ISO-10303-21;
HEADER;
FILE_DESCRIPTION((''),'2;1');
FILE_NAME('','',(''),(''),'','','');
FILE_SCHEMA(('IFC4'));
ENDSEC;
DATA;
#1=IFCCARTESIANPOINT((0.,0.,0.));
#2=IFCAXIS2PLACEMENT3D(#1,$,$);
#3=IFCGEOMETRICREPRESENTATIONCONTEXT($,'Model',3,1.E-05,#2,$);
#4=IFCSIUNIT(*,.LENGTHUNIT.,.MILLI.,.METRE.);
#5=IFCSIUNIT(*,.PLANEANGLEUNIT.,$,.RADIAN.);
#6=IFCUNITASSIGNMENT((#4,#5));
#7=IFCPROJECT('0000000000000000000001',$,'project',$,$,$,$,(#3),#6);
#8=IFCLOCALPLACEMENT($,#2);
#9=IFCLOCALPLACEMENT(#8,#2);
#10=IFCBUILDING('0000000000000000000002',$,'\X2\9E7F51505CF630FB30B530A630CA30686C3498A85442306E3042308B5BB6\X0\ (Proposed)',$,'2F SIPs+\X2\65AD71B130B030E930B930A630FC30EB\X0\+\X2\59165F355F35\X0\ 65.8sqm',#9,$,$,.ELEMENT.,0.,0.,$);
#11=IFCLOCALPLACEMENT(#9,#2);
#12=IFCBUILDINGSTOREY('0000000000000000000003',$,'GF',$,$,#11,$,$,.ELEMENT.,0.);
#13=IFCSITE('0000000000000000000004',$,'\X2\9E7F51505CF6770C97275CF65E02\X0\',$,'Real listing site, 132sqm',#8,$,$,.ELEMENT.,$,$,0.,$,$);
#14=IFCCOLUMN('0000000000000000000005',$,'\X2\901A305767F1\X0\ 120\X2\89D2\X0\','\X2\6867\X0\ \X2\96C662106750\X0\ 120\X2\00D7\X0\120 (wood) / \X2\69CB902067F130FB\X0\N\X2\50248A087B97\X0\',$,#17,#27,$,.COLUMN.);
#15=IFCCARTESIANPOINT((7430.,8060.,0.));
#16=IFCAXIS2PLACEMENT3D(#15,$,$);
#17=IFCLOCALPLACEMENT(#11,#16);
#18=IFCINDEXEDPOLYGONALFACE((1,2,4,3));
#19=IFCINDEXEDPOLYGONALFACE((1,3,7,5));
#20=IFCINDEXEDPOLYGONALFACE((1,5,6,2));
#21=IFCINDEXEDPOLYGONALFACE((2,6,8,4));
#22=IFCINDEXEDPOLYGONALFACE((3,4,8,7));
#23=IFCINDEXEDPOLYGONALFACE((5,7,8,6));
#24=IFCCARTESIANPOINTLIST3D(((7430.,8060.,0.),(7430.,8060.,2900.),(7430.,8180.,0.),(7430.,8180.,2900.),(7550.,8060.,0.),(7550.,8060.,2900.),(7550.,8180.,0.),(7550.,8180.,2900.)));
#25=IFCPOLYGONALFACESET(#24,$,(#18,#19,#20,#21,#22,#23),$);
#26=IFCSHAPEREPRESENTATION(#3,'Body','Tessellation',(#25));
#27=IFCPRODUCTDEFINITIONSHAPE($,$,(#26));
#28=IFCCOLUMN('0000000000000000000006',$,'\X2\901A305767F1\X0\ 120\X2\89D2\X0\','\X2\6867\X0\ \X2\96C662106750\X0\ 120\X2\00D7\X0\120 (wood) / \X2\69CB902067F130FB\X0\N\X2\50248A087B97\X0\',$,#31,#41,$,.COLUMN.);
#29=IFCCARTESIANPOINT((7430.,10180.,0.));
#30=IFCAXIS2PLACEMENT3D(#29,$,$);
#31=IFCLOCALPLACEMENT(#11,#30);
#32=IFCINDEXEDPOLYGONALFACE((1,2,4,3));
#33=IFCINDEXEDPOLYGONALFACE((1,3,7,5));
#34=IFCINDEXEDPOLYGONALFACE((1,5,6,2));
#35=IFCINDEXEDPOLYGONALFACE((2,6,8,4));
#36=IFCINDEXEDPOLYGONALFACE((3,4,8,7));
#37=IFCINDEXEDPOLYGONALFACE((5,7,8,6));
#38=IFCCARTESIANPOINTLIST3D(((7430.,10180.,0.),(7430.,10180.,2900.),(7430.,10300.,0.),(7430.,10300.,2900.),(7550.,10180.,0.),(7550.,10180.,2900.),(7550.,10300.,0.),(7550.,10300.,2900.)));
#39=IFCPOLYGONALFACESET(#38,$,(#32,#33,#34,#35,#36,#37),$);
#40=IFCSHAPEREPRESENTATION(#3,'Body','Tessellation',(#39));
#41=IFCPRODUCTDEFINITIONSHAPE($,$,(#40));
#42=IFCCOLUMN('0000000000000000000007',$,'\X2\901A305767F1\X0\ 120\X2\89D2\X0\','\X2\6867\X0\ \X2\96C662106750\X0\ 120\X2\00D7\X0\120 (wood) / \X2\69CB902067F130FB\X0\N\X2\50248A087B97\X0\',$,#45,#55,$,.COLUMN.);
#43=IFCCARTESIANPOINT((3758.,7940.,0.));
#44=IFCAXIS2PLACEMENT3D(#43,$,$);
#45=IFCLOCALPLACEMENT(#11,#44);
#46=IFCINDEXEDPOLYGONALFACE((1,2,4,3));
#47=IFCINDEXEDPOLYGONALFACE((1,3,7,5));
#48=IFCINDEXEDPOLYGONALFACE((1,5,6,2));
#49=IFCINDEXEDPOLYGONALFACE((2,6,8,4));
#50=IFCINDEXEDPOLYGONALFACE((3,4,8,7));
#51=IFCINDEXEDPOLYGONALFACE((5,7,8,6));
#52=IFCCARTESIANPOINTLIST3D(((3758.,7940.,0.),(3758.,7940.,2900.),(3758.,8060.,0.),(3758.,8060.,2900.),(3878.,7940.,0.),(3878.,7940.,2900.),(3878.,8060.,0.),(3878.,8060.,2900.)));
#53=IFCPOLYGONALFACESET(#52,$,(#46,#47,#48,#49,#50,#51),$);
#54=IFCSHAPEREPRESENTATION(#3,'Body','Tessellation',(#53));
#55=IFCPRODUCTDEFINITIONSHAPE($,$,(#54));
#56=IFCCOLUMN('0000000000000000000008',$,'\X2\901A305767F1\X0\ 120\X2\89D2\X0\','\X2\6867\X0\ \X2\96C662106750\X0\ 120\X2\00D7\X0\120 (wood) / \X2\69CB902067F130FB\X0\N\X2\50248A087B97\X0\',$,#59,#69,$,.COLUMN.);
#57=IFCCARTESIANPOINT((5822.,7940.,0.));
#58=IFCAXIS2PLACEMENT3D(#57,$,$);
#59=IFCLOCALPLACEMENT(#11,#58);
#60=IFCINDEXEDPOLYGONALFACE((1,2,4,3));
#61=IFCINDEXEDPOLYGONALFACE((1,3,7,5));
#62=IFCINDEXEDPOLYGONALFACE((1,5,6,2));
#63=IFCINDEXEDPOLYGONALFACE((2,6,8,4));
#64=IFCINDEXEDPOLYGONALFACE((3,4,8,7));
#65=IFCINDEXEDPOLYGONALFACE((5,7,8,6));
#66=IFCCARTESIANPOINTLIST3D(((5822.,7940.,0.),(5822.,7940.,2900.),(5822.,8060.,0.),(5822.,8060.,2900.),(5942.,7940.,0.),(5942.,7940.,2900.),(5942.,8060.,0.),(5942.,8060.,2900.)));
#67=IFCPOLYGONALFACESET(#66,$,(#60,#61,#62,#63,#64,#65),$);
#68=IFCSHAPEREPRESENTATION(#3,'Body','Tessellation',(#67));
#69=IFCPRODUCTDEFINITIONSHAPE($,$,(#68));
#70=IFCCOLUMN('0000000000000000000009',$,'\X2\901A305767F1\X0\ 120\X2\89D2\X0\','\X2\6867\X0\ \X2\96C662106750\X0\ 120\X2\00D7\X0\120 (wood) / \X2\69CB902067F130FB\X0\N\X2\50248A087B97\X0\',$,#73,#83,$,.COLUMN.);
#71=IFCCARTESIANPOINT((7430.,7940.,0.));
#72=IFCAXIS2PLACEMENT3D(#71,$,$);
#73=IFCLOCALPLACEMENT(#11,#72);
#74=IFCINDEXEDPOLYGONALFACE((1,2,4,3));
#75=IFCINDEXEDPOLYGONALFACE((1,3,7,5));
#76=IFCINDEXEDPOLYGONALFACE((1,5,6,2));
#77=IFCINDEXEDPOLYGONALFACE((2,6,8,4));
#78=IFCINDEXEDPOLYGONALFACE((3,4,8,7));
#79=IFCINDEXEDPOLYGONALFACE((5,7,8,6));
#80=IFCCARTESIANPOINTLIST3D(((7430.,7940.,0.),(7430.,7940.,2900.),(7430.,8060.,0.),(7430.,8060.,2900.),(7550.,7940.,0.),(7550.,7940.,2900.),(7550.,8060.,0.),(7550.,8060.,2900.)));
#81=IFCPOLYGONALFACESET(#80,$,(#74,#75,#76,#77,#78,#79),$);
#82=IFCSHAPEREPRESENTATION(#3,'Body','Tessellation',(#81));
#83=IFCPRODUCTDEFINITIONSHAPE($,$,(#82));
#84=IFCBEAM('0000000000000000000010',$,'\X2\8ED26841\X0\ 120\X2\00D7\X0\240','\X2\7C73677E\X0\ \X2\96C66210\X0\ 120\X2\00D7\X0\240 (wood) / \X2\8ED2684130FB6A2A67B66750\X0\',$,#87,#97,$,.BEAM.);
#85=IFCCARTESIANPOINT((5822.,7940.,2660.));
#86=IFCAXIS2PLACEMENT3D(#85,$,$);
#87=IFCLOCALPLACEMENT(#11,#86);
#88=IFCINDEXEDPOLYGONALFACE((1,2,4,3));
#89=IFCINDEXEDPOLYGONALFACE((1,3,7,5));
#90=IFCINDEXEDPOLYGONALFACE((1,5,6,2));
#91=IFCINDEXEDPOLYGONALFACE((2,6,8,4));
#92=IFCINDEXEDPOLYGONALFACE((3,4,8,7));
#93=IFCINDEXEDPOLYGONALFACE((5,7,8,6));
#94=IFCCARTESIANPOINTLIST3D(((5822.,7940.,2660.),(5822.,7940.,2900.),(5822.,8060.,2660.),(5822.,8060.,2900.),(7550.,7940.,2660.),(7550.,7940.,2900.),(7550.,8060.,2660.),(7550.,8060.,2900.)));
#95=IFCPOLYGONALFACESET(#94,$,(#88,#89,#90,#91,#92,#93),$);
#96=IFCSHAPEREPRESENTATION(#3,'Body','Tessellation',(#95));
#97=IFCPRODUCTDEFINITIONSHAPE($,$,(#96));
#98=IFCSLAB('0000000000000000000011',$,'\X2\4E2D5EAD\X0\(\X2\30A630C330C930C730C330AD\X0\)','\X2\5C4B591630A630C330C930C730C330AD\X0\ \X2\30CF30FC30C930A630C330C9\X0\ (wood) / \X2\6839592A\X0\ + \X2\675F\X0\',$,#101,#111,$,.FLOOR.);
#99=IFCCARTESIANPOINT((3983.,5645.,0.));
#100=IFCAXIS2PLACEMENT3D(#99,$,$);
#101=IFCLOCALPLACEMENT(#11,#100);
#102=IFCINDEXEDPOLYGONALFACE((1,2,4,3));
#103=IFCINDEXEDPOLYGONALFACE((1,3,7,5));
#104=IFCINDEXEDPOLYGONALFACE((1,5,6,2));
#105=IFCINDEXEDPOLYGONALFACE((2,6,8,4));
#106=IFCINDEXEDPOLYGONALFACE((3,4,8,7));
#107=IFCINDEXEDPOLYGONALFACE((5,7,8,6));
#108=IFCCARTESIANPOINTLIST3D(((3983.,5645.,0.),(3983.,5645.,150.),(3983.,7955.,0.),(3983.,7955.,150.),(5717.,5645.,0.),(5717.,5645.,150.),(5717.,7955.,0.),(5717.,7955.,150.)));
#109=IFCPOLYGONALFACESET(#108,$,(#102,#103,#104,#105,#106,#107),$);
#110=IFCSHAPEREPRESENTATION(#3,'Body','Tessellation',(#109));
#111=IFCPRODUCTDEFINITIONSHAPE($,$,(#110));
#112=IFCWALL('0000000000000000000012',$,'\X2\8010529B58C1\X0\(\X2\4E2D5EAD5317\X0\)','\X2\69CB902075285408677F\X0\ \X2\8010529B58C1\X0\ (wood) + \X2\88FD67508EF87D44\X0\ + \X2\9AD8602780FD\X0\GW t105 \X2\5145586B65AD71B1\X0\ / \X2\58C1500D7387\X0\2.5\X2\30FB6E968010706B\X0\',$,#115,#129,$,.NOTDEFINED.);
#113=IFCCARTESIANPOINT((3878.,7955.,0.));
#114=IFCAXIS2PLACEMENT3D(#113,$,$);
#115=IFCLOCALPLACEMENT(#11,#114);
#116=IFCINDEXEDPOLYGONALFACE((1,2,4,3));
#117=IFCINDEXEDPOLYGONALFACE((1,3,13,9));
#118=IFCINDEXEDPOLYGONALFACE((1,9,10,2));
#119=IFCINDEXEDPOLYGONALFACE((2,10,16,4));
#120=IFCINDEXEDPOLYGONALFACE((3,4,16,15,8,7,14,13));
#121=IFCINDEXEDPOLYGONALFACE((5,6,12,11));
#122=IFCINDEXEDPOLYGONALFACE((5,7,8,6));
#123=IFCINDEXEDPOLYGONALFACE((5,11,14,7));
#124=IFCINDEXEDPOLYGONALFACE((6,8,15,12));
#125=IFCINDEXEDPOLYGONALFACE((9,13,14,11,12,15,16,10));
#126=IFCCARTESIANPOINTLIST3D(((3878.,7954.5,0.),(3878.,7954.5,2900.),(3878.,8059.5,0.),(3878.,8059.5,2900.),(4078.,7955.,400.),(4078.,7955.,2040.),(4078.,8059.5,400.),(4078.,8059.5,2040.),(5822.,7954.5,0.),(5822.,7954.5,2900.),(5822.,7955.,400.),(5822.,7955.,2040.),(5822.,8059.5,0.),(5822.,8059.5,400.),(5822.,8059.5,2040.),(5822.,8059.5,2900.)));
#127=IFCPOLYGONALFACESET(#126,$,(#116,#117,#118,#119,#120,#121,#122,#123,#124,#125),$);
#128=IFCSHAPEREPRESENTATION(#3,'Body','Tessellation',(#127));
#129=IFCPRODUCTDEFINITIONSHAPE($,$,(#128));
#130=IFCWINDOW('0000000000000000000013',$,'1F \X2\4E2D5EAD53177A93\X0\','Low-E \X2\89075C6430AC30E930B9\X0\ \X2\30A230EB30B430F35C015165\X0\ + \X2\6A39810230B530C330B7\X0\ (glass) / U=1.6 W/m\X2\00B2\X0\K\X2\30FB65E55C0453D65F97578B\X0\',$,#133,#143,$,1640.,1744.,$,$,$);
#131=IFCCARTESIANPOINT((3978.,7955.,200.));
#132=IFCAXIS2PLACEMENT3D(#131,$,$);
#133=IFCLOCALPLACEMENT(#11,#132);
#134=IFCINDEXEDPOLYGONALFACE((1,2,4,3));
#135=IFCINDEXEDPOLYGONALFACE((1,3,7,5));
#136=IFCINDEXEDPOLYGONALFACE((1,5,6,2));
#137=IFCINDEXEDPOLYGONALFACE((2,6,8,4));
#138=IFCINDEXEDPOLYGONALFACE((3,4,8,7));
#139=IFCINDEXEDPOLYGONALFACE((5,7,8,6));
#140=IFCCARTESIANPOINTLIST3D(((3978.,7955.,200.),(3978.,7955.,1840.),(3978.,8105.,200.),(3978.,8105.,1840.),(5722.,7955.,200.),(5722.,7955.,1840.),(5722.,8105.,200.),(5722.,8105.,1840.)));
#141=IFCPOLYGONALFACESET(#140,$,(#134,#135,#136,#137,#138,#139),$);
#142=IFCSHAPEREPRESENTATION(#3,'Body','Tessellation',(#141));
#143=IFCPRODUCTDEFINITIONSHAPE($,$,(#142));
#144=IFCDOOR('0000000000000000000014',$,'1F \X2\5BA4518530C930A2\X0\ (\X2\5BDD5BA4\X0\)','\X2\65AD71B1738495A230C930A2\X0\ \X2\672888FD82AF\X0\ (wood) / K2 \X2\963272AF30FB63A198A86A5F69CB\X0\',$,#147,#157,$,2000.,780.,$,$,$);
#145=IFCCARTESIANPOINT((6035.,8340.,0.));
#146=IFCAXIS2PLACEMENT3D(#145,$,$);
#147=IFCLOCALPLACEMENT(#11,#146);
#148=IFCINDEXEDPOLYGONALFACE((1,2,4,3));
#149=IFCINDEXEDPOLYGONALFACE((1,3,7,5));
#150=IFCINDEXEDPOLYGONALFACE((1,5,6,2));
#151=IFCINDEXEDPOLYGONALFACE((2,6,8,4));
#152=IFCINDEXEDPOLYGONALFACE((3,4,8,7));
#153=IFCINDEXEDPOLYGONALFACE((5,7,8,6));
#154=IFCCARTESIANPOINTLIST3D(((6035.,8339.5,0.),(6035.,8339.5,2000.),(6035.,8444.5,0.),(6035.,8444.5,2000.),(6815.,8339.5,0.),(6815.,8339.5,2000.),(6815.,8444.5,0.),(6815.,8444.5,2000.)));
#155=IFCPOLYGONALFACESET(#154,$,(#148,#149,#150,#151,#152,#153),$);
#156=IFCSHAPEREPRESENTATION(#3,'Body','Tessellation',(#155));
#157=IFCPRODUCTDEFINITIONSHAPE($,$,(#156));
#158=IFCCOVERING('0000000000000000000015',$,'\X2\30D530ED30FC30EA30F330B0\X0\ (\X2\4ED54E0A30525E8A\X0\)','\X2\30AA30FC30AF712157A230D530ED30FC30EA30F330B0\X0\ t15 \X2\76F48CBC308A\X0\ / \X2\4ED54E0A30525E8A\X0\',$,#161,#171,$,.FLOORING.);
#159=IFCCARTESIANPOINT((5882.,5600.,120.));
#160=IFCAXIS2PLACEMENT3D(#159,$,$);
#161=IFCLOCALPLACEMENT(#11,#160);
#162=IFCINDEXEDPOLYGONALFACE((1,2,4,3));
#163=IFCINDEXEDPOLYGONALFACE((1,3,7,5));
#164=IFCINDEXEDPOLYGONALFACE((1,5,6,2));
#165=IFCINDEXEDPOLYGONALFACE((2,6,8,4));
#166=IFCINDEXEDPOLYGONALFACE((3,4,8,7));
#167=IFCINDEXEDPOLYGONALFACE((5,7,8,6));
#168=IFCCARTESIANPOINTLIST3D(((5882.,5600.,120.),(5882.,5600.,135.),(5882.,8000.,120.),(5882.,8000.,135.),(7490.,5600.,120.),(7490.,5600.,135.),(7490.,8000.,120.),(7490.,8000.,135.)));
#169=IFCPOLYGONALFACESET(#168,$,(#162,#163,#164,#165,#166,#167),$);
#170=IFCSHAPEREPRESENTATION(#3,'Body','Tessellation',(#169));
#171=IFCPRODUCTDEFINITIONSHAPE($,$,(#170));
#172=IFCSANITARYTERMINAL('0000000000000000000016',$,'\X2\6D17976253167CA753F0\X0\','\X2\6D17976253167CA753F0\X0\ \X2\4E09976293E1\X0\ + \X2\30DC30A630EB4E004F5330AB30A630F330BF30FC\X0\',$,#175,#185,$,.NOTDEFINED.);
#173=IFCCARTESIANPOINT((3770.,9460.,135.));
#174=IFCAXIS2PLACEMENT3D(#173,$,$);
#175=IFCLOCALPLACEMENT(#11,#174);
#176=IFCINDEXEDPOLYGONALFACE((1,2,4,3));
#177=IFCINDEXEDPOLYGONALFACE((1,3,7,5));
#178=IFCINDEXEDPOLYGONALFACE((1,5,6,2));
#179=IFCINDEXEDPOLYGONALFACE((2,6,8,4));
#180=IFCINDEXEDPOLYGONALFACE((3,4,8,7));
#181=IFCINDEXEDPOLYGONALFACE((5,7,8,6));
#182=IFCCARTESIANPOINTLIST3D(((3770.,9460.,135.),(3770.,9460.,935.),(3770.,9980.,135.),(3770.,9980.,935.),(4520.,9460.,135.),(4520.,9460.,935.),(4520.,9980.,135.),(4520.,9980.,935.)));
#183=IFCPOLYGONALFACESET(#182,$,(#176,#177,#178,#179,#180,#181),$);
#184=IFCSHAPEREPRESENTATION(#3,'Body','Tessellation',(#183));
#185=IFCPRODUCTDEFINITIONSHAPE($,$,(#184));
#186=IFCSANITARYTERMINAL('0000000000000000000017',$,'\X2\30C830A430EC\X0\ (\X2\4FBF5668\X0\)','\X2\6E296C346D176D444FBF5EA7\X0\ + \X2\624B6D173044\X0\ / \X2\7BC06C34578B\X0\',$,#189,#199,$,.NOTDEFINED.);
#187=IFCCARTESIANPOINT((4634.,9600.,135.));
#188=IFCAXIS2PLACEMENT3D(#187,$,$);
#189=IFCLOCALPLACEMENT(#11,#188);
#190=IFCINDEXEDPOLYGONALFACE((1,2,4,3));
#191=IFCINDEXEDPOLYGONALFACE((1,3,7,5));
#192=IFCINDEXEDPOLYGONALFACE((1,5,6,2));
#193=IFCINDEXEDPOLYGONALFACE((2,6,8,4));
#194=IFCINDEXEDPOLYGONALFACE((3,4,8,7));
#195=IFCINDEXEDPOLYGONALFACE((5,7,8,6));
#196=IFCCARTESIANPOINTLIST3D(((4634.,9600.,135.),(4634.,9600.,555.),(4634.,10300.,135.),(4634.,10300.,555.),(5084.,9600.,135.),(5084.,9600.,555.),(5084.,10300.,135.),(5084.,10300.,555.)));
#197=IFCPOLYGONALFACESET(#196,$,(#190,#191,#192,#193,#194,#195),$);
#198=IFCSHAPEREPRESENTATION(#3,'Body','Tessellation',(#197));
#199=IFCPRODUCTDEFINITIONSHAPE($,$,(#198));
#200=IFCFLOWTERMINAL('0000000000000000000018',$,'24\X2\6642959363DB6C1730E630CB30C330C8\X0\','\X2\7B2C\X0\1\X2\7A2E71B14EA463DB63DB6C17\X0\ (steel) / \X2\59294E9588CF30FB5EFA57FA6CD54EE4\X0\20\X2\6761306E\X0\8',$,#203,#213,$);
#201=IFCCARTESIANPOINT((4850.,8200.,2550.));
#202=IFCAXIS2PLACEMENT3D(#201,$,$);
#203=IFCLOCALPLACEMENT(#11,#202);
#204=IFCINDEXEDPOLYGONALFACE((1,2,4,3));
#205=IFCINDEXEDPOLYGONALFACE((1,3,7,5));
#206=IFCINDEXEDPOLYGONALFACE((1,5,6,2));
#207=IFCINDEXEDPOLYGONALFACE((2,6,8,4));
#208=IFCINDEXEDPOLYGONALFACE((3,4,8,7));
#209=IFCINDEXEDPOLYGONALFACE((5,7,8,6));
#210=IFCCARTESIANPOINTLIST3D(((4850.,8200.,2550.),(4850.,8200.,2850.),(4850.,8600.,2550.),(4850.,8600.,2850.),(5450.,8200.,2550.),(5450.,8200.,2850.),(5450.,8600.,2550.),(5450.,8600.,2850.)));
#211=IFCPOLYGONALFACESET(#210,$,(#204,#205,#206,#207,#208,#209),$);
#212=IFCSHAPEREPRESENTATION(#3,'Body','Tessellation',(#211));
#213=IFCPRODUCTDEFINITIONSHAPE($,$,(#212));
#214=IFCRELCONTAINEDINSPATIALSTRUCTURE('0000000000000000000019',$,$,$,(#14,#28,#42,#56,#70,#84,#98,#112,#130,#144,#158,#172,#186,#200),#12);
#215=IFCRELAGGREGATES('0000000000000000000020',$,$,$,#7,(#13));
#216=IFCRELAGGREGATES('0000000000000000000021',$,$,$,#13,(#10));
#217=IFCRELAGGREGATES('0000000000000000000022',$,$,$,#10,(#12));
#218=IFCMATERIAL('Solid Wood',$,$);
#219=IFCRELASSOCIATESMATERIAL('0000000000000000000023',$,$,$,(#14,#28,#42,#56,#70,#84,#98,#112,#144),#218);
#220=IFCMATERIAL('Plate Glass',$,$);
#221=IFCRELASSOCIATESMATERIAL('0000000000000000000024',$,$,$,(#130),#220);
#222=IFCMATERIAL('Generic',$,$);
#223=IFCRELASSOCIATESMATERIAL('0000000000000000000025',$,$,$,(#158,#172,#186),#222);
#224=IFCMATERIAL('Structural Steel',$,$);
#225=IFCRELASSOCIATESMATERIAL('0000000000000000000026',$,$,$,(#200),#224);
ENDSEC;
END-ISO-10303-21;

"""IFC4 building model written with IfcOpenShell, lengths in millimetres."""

from ifc_helpers import new_model, si_unit, frame, frame_2d, origin, place, context, project, spatial, rectangle, extrude, material, element, fill, save


model = new_model("IFC4")

# Units and contexts
model_context = context("Model", 3, precision=1e-05, world=origin())
ifc_project = project(units=[si_unit("LENGTHUNIT", "METRE", prefix="MILLI"), si_unit("PLANEANGLEUNIT", "RADIAN")], contexts=[model_context])

# Site, building, storey
site_placement = place(None, origin())
site = spatial("IfcSite", under=ifc_project, at=site_placement, Name="鹿児島県霧島市", ObjectType="Real listing site, 132sqm", CompositionType="ELEMENT", RefElevation=0.0)
building_placement = place(site_placement, origin())
building = spatial("IfcBuilding", under=site, at=building_placement, Name="鹿児島・サウナと水風呂のある家 (Proposed)", ObjectType="2F SIPs+断熱グラスウール+外張張 65.8sqm", CompositionType="ELEMENT", ElevationOfRefHeight=0.0, ElevationOfTerrain=0.0)
storey_placement = place(building_placement, origin())
storey = spatial("IfcBuildingStorey", under=building, at=storey_placement, Name="GF", CompositionType="ELEMENT", Elevation=0.0)

# Columns
ifc_material_1 = material(Name="Solid Wood")
column_1_placement = place(storey_placement, frame((7430.0, 8060.0, 0.0)))
element("IfcColumn", 1, at=column_1_placement, inside=storey, material=ifc_material_1, Name="通し柱 120角", Description="桧 集成材 120×120 (wood) / 構造柱・N値計算", PredefinedType="COLUMN", context=model_context, shape_type="SweptSolid", body=[
    extrude(rectangle(XDim=120.0, YDim=120.0, at=frame_2d((60.0, 60.0))), frame((7430.0, 8060.0, 0.0)), (0.0, 0.0, 1.0), 2900.0),
])
column_2_placement = place(storey_placement, frame((7430.0, 10180.0, 0.0)))
element("IfcColumn", 2, at=column_2_placement, inside=storey, material=ifc_material_1, Name="通し柱 120角", Description="桧 集成材 120×120 (wood) / 構造柱・N値計算", PredefinedType="COLUMN", context=model_context, shape_type="SweptSolid", body=[
    extrude(rectangle(XDim=120.0, YDim=120.0, at=frame_2d((60.0, 60.0))), frame((7430.0, 10180.0, 0.0)), (0.0, 0.0, 1.0), 2900.0),
])
column_3_placement = place(storey_placement, frame((3758.0, 7940.0, 0.0)))
element("IfcColumn", 3, at=column_3_placement, inside=storey, material=ifc_material_1, Name="通し柱 120角", Description="桧 集成材 120×120 (wood) / 構造柱・N値計算", PredefinedType="COLUMN", context=model_context, shape_type="SweptSolid", body=[
    extrude(rectangle(XDim=120.0, YDim=120.0, at=frame_2d((60.0, 60.0))), frame((3758.0, 7940.0, 0.0)), (0.0, 0.0, 1.0), 2900.0),
])
column_4_placement = place(storey_placement, frame((5822.0, 7940.0, 0.0)))
element("IfcColumn", 4, at=column_4_placement, inside=storey, material=ifc_material_1, Name="通し柱 120角", Description="桧 集成材 120×120 (wood) / 構造柱・N値計算", PredefinedType="COLUMN", context=model_context, shape_type="SweptSolid", body=[
    extrude(rectangle(XDim=120.0, YDim=120.0, at=frame_2d((60.0, 60.0))), frame((5822.0, 7940.0, 0.0)), (0.0, 0.0, 1.0), 2900.0),
])
column_5_placement = place(storey_placement, frame((7430.0, 7940.0, 0.0)))
element("IfcColumn", 5, at=column_5_placement, inside=storey, material=ifc_material_1, Name="通し柱 120角", Description="桧 集成材 120×120 (wood) / 構造柱・N値計算", PredefinedType="COLUMN", context=model_context, shape_type="SweptSolid", body=[
    extrude(rectangle(XDim=120.0, YDim=120.0, at=frame_2d((60.0, 60.0))), frame((7430.0, 7940.0, 0.0)), (0.0, 0.0, 1.0), 2900.0),
])

# Beam
beam_1_placement = place(storey_placement, frame((5822.0, 7940.0, 2660.0)))
element("IfcBeam", 6, at=beam_1_placement, inside=storey, material=ifc_material_1, Name="軒桁 120×240", Description="米松 集成 120×240 (wood) / 軒桁・横架材", PredefinedType="BEAM", context=model_context, shape_type="SweptSolid", body=[
    extrude(rectangle(XDim=1728.0, YDim=120.0, at=frame_2d((864.0, 60.0))), frame((5822.0, 7940.0, 2660.0)), (0.0, 0.0, 1.0), 240.0),
])

# Slab
slab_placement = place(storey_placement, frame((3983.0, 5645.0, 0.0)))
element("IfcSlab", 7, at=slab_placement, inside=storey, material=ifc_material_1, Name="中庭(ウッドデッキ)", Description="屋外ウッドデッキ ハードウッド (wood) / 根太 + 束", PredefinedType="FLOOR", context=model_context, shape_type="SweptSolid", body=[
    extrude(rectangle(XDim=1734.0, YDim=2310.0, at=frame_2d((867.0, 1155.0))), frame((3983.0, 5645.0, 0.0)), (0.0, 0.0, 1.0), 150.0),
])

# Wall, opening, window
wall_1_placement = place(storey_placement, frame((3878.0, 7955.0, 0.0)))
wall_1 = element("IfcWall", 8, at=wall_1_placement, inside=storey, material=ifc_material_1, Name="耐力壁(中庭北)", Description="構造用合板 耐力壁 (wood) + 製材軸組 + 高性能GW t105 充填断熱 / 壁倍率2.5・準耐火", PredefinedType="NOTDEFINED", context=model_context, shape_type="SweptSolid", body=[
    extrude(rectangle(XDim=1944.0, YDim=105.0, at=frame_2d((972.0, 52.0))), frame((3878.0, 7955.0, 0.0)), (0.0, 0.0, 1.0), 2900.0),
])
opening_placement = place(storey_placement, frame((3978.0, 7955.0, 200.0)))
opening = element("IfcOpeningElement", 9, at=opening_placement, cuts=wall_1, PredefinedType="NOTDEFINED", context=model_context, shape_type="SweptSolid", body=[
    extrude(rectangle(XDim=1744.0, YDim=150.0, at=frame_2d((872.0, 75.0))), frame((3978.0, 7955.0, 200.0)), (0.0, 0.0, 1.0), 1640.0),
])
ifc_material_2 = material(Name="Plate Glass")
window_placement = place(storey_placement, frame((3978.0, 7955.0, 200.0)))
window = element("IfcWindow", 10, at=window_placement, inside=storey, material=ifc_material_2, Name="1F 中庭北窓", Description="Low-E 複層ガラス アルゴン封入 + 樹脂サッシ (glass) / U=1.6 W/m²K・日射取得型", OverallHeight=1640.0, OverallWidth=1744.0, context=model_context, shape_type="SweptSolid", body=[
    extrude(rectangle(XDim=1744.0, YDim=150.0, at=frame_2d((872.0, 75.0))), frame((3978.0, 7955.0, 200.0)), (0.0, 0.0, 1.0), 1640.0),
])
fill(opening, window)

# Door
door_placement = place(storey_placement, frame((6035.0, 8340.0, 0.0)))
element("IfcDoor", 11, at=door_placement, inside=storey, material=ifc_material_1, Name="1F 室内ドア (寝室)", Description="断熱玄関ドア 木製芯 (wood) / K2 防犯・採風機構", OverallHeight=2000.0, OverallWidth=780.0, context=model_context, shape_type="SweptSolid", body=[
    extrude(rectangle(XDim=780.0, YDim=105.0, at=frame_2d((390.0, 52.0))), frame((6035.0, 8340.0, 0.0)), (0.0, 0.0, 1.0), 2000.0),
])

# Covering
ifc_material_3 = material(Name="Generic")
covering_placement = place(storey_placement, frame((5882.0, 5600.0, 120.0)))
element("IfcCovering", 12, at=covering_placement, inside=storey, material=ifc_material_3, Name="フローリング (仕上げ床)", Description="オーク無垢フローリング t15 直貼り / 仕上げ床", PredefinedType="FLOORING", context=model_context, shape_type="SweptSolid", body=[
    extrude(rectangle(XDim=1608.0, YDim=2400.0, at=frame_2d((804.0, 1200.0))), frame((5882.0, 5600.0, 120.0)), (0.0, 0.0, 1.0), 15.0),
])

# Sanitary terminals
sanitary_terminal_1_placement = place(storey_placement, frame((3770.0, 9460.0, 135.0)))
element("IfcSanitaryTerminal", 13, at=sanitary_terminal_1_placement, inside=storey, material=ifc_material_3, Name="洗面化粧台", Description="洗面化粧台 三面鏡 + ボウル一体カウンター", PredefinedType="NOTDEFINED", context=model_context, shape_type="SweptSolid", body=[
    extrude(rectangle(XDim=750.0, YDim=520.0, at=frame_2d((375.0, 260.0))), frame((3770.0, 9460.0, 135.0)), (0.0, 0.0, 1.0), 800.0),
])
sanitary_terminal_2_placement = place(storey_placement, frame((4634.0, 9600.0, 135.0)))
element("IfcSanitaryTerminal", 14, at=sanitary_terminal_2_placement, inside=storey, material=ifc_material_3, Name="トイレ (便器)", Description="温水洗浄便座 + 手洗い / 節水型", PredefinedType="NOTDEFINED", context=model_context, shape_type="SweptSolid", body=[
    extrude(rectangle(XDim=450.0, YDim=700.0, at=frame_2d((225.0, 350.0))), frame((4634.0, 9600.0, 135.0)), (0.0, 0.0, 1.0), 420.0),
])

# Flow terminal
ifc_material_4 = material(Name="Structural Steel")
flow_terminal_placement = place(storey_placement, frame((4850.0, 8200.0, 2550.0)))
element("IfcFlowTerminal", 15, at=flow_terminal_placement, inside=storey, material=ifc_material_4, Name="24時間換気ユニット", Description="第1種熱交換換気 (steel) / 天井裏・建基法令20条の8", context=model_context, shape_type="SweptSolid", body=[
    extrude(rectangle(XDim=600.0, YDim=400.0, at=frame_2d((300.0, 200.0))), frame((4850.0, 8200.0, 2550.0)), (0.0, 0.0, 1.0), 300.0),
])

save(model, "model.ifc")
